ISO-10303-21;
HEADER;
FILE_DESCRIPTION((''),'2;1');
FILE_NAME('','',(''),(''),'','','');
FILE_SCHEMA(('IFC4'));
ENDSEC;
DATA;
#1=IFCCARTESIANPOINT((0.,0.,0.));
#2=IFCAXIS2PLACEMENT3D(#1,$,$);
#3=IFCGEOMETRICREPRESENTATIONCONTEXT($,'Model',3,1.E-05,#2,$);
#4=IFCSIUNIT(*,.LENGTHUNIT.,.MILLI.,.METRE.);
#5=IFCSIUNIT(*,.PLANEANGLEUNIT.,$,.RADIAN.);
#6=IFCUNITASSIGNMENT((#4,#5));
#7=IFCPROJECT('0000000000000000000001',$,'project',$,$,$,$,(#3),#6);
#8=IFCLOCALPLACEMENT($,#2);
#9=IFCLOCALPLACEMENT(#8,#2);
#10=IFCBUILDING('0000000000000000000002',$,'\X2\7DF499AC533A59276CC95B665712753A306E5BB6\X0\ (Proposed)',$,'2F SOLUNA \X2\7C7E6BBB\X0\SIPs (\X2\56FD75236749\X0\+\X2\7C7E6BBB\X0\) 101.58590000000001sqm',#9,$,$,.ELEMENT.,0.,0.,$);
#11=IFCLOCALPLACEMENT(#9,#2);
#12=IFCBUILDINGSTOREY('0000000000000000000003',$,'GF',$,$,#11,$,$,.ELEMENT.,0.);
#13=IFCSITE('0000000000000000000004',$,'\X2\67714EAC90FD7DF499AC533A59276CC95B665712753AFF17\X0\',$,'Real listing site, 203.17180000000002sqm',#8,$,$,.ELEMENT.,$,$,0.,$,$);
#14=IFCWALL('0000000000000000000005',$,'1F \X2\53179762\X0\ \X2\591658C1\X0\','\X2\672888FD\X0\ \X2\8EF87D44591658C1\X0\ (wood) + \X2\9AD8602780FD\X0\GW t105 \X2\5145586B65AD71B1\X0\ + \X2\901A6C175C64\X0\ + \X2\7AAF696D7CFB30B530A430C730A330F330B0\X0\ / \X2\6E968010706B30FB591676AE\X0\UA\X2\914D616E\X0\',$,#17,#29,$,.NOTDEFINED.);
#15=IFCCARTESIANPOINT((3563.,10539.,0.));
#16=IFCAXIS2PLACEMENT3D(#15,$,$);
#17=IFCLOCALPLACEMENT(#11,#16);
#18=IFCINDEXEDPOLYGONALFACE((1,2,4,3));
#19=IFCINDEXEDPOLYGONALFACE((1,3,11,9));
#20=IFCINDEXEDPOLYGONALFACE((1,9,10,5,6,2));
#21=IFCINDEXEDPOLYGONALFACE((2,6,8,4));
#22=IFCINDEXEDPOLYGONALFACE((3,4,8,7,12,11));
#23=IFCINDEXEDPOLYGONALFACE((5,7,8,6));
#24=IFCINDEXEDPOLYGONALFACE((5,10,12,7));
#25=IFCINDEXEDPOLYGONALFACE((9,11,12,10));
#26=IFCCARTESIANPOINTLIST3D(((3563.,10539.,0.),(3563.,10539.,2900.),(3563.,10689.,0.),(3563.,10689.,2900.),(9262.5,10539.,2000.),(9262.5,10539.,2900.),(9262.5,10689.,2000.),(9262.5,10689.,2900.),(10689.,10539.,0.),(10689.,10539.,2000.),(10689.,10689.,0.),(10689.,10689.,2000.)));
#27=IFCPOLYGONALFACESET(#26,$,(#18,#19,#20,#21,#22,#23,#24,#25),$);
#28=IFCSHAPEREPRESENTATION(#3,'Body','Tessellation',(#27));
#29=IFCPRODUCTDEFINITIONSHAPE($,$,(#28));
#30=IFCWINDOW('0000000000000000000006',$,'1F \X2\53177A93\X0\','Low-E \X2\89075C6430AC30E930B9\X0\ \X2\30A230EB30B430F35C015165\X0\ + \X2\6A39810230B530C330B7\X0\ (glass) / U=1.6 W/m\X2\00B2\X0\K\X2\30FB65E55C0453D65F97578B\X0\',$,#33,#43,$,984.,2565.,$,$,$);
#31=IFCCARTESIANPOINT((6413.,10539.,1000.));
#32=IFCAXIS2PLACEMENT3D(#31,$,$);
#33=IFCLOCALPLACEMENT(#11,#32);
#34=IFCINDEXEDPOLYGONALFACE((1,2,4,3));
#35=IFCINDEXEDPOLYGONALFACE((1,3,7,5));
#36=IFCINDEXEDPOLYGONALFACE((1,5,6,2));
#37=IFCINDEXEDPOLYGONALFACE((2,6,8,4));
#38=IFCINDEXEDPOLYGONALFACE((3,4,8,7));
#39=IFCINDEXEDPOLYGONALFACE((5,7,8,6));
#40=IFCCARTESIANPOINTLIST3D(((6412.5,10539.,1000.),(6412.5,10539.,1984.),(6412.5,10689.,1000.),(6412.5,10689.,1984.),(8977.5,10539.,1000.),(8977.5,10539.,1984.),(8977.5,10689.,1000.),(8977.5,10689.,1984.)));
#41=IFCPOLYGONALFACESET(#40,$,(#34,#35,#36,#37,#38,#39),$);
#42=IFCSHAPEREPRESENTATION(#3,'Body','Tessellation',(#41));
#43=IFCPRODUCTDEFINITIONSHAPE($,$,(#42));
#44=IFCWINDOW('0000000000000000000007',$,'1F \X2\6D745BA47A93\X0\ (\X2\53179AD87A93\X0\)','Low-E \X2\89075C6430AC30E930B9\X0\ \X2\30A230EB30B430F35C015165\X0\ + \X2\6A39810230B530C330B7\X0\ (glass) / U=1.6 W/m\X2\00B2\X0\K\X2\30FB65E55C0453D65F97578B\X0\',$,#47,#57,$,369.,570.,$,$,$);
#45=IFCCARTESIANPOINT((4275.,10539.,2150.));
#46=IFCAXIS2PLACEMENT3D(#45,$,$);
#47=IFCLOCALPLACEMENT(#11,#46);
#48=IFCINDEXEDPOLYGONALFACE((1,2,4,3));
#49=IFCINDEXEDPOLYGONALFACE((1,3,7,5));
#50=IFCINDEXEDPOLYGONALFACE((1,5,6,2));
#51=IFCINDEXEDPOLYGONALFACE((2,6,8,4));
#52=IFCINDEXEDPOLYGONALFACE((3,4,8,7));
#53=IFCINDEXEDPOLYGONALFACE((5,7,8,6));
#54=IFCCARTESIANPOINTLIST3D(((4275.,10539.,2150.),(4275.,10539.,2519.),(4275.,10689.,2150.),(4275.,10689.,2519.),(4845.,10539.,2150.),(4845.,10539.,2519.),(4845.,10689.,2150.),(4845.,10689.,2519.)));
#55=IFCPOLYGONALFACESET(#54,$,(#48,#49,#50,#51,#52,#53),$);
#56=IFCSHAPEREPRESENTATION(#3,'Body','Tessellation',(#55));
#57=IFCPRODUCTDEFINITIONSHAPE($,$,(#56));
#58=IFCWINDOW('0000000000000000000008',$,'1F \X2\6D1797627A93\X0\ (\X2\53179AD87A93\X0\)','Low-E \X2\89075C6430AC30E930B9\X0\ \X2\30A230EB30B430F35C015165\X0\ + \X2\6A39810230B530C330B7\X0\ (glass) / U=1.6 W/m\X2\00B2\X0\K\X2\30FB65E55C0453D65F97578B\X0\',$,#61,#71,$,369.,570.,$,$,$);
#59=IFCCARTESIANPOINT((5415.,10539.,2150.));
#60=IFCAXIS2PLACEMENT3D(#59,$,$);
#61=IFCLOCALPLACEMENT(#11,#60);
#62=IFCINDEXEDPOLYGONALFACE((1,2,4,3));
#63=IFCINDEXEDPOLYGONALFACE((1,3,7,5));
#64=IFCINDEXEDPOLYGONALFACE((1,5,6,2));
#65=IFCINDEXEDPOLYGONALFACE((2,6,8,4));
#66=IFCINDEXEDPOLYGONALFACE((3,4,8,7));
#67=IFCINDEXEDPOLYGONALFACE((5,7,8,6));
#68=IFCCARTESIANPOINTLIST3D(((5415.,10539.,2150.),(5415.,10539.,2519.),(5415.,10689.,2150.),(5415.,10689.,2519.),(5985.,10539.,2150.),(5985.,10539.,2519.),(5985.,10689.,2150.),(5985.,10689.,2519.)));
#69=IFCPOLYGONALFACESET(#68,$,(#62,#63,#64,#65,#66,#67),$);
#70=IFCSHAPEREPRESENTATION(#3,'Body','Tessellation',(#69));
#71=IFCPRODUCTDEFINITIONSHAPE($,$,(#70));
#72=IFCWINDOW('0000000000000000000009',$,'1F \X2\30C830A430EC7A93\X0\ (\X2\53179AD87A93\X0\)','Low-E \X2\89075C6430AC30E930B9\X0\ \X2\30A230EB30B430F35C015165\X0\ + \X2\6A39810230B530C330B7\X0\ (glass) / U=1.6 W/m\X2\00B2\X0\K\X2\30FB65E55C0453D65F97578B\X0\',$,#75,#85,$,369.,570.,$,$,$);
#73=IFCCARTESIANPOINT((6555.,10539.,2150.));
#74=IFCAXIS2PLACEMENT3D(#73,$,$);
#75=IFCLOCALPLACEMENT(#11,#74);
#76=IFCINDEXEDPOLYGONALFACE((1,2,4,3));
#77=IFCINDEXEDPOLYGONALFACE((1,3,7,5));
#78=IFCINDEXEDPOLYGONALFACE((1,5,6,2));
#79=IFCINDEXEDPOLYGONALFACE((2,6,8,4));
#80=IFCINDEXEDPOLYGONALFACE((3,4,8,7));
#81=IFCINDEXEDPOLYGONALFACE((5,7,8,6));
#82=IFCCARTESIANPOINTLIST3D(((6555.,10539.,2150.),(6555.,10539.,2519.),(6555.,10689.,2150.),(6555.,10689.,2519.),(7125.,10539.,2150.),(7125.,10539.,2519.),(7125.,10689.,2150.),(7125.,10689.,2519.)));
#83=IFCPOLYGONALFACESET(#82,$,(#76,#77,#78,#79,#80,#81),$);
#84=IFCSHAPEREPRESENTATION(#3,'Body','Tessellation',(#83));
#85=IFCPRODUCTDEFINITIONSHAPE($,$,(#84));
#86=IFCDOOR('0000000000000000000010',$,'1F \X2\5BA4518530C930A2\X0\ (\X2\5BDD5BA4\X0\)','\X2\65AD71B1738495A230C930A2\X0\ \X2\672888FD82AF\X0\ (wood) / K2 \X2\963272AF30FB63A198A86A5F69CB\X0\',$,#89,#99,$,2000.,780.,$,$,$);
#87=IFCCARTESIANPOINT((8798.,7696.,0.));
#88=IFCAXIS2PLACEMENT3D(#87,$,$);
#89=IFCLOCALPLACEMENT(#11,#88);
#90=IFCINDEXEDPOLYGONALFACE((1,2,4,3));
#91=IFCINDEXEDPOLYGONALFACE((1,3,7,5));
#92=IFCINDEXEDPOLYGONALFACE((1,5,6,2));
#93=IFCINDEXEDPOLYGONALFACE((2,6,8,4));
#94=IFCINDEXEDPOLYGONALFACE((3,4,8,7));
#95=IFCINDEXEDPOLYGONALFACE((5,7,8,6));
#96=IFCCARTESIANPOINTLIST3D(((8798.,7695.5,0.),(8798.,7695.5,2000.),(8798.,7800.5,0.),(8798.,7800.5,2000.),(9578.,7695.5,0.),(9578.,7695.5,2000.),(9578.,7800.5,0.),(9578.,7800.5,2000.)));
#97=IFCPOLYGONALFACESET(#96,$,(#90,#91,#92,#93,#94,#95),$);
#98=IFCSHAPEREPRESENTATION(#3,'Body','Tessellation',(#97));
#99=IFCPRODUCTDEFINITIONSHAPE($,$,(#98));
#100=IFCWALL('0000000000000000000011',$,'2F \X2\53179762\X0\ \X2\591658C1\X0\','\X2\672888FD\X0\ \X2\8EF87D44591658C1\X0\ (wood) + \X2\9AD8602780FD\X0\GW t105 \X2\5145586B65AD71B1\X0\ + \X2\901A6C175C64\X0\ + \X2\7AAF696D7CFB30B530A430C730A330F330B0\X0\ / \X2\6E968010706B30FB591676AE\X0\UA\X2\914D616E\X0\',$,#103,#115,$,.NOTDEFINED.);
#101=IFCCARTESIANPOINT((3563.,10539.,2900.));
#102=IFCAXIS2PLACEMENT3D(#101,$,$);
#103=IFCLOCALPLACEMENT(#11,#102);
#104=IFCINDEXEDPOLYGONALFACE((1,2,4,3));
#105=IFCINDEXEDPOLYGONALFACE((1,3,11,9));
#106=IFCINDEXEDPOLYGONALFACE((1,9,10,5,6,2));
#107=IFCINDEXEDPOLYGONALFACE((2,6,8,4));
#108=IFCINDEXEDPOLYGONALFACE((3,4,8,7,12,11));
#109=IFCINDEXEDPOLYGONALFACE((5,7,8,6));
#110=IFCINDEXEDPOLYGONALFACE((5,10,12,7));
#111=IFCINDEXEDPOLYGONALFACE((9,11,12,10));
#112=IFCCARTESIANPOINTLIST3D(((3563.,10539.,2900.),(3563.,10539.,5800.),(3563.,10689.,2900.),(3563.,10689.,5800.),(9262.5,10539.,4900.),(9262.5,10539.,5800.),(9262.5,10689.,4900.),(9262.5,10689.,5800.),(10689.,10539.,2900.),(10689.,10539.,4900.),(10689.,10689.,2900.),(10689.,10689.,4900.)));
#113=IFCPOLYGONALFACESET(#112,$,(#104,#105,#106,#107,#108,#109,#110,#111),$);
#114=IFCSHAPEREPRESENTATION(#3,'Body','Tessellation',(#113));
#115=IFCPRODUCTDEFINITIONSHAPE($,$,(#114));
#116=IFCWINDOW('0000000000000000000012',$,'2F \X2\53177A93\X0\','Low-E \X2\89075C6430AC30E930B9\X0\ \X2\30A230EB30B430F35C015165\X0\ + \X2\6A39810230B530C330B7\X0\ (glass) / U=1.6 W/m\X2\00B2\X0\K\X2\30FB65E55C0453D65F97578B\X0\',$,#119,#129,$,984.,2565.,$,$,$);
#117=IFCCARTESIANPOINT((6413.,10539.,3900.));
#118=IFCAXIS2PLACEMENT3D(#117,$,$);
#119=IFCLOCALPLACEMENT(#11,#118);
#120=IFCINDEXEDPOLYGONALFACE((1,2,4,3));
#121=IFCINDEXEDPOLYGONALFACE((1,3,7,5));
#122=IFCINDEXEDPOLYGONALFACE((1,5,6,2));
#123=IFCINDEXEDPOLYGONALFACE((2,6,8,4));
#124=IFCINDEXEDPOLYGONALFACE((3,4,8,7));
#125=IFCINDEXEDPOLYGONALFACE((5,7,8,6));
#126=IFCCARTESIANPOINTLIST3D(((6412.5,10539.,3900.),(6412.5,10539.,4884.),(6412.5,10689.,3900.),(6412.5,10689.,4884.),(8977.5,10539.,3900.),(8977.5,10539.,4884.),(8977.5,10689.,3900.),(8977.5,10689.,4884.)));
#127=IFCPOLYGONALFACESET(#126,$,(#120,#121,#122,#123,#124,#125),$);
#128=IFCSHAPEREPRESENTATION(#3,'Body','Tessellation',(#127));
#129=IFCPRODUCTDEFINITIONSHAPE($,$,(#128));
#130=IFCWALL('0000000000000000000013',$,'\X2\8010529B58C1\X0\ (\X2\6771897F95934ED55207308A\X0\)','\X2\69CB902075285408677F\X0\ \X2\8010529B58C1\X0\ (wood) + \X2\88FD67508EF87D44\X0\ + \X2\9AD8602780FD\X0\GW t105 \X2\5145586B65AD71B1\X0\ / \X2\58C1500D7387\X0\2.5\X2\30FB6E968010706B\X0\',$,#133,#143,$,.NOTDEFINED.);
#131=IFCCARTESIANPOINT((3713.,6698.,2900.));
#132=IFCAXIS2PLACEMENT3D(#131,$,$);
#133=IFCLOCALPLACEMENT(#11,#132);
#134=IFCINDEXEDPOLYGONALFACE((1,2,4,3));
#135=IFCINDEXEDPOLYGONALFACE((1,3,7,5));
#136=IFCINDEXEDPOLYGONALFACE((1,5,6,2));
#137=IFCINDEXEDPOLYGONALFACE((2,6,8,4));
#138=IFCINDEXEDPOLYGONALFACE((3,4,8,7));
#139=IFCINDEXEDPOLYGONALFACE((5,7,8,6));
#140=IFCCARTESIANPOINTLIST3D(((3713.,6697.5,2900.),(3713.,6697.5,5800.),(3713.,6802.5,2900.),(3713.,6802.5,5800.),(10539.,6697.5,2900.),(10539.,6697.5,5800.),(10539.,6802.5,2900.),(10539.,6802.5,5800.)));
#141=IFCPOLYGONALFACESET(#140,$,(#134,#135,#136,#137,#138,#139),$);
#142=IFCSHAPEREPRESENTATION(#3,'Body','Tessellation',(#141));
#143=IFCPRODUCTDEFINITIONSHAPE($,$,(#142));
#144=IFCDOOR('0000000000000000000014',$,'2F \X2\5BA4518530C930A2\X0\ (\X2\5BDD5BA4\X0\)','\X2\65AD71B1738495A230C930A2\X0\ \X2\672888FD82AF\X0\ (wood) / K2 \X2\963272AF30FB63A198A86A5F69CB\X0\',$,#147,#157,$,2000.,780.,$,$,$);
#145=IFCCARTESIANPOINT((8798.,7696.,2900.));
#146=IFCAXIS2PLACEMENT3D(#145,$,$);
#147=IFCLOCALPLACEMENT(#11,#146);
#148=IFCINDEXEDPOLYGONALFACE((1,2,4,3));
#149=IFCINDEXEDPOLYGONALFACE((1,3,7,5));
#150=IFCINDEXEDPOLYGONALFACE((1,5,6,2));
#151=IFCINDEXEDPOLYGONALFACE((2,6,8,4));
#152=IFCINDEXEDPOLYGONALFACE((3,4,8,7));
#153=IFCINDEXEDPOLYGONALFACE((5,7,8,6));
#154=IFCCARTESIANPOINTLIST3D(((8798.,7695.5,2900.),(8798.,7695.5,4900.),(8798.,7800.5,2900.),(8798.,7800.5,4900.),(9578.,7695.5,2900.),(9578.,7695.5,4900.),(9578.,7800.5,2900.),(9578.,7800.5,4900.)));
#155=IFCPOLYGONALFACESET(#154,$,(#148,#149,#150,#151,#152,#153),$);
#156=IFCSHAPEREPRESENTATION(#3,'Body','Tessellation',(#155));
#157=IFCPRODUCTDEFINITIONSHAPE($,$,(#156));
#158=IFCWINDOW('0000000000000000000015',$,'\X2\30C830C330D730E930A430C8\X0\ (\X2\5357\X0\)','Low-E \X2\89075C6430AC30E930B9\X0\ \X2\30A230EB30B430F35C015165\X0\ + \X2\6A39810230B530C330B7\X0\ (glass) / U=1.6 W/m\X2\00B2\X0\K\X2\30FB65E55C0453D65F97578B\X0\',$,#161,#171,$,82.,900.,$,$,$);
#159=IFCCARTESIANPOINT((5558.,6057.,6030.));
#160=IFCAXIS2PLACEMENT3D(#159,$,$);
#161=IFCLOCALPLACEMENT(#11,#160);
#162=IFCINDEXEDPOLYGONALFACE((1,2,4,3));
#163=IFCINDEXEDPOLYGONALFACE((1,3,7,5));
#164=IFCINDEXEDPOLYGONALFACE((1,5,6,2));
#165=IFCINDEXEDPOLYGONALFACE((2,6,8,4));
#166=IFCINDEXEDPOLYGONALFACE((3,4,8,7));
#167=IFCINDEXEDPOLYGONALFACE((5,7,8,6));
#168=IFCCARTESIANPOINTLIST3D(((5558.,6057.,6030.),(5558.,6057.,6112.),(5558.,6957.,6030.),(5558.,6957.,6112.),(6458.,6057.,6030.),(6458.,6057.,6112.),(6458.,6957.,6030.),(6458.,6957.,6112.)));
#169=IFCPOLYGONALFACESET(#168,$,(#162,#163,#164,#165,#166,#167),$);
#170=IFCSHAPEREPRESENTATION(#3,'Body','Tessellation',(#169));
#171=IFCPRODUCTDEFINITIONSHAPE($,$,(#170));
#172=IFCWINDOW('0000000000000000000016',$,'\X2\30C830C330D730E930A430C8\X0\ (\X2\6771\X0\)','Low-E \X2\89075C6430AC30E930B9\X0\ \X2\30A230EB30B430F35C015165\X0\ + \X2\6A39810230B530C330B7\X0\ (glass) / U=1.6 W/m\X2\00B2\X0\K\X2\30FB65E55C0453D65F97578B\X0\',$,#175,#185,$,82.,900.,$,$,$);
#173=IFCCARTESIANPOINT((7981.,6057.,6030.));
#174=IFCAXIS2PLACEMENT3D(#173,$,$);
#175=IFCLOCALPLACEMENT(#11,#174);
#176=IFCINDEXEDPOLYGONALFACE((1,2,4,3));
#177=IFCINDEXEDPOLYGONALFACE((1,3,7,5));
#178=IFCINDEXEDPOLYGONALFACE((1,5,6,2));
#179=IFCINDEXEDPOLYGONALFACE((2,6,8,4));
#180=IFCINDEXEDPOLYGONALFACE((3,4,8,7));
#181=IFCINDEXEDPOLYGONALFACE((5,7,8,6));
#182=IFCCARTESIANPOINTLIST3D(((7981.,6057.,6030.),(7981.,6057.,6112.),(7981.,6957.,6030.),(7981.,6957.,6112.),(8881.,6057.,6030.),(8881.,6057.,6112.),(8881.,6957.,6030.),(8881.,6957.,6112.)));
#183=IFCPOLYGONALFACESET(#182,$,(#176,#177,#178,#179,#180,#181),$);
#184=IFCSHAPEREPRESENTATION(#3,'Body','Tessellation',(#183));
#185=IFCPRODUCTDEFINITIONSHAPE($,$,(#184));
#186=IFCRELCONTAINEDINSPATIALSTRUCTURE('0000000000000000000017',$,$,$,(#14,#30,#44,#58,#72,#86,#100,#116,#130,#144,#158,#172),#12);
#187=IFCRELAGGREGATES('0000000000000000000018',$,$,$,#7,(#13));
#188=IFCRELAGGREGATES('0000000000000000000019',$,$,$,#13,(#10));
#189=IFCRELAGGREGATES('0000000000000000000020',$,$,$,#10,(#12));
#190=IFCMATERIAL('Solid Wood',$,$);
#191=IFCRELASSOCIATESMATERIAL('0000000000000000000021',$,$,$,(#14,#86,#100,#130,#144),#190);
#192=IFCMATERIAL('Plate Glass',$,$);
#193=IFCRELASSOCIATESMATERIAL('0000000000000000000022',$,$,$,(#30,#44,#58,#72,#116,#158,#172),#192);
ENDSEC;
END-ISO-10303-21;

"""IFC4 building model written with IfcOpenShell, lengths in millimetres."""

from ifc_helpers import new_model, si_unit, frame, frame_2d, origin, place, context, project, spatial, rectangle, extrude, material, element, fill, save


model = new_model("IFC4")

# Units and contexts
model_context = context("Model", 3, precision=1e-05, world=origin())
ifc_project = project(units=[si_unit("LENGTHUNIT", "METRE", prefix="MILLI"), si_unit("PLANEANGLEUNIT", "RADIAN")], contexts=[model_context])

# Site, building, storey
site_placement = place(None, origin())
site = spatial("IfcSite", under=ifc_project, at=site_placement, Name="東京都練馬区大泉学園町７", ObjectType="Real listing site, 203.17180000000002sqm", CompositionType="ELEMENT", RefElevation=0.0)
building_placement = place(site_placement, origin())
building = spatial("IfcBuilding", under=site, at=building_placement, Name="練馬区大泉学園町の家 (Proposed)", ObjectType="2F SOLUNA 籾殻SIPs (国産杉+籾殻) 101.58590000000001sqm", CompositionType="ELEMENT", ElevationOfRefHeight=0.0, ElevationOfTerrain=0.0)
storey_placement = place(building_placement, origin())
storey = spatial("IfcBuildingStorey", under=building, at=storey_placement, Name="GF", CompositionType="ELEMENT", Elevation=0.0)

# Wall, openings, windows
ifc_material_1 = material(Name="Solid Wood")
wall_1_placement = place(storey_placement, frame((3563.0, 10539.0, 0.0)))
wall_1 = element("IfcWall", 1, at=wall_1_placement, inside=storey, material=ifc_material_1, Name="1F 北面 外壁", Description="木製 軸組外壁 (wood) + 高性能GW t105 充填断熱 + 通気層 + 窯業系サイディング / 準耐火・外皮UA配慮", PredefinedType="NOTDEFINED", context=model_context, shape_type="SweptSolid", body=[
    extrude(rectangle(XDim=7126.0, YDim=150.0, at=frame_2d((3563.0, 75.0))), frame((3563.0, 10539.0, 0.0)), (0.0, 0.0, 1.0), 2900.0),
])
opening_1_placement = place(storey_placement, frame((6413.0, 10539.0, 1000.0)))
opening_1 = element("IfcOpeningElement", 2, at=opening_1_placement, cuts=wall_1, PredefinedType="NOTDEFINED", context=model_context, shape_type="SweptSolid", body=[
    extrude(rectangle(XDim=2565.0, YDim=150.0, at=frame_2d((1282.0, 75.0))), frame((6413.0, 10539.0, 1000.0)), (0.0, 0.0, 1.0), 984.0),
])
opening_2_placement = place(storey_placement, frame((4275.0, 10539.0, 2150.0)))
opening_2 = element("IfcOpeningElement", 3, at=opening_2_placement, cuts=wall_1, PredefinedType="NOTDEFINED", context=model_context, shape_type="SweptSolid", body=[
    extrude(rectangle(XDim=570.0, YDim=150.0, at=frame_2d((285.0, 75.0))), frame((4275.0, 10539.0, 2150.0)), (0.0, 0.0, 1.0), 369.0),
])
opening_3_placement = place(storey_placement, frame((5415.0, 10539.0, 2150.0)))
opening_3 = element("IfcOpeningElement", 4, at=opening_3_placement, cuts=wall_1, PredefinedType="NOTDEFINED", context=model_context, shape_type="SweptSolid", body=[
    extrude(rectangle(XDim=570.0, YDim=150.0, at=frame_2d((285.0, 75.0))), frame((5415.0, 10539.0, 2150.0)), (0.0, 0.0, 1.0), 369.0),
])
opening_4_placement = place(storey_placement, frame((6555.0, 10539.0, 2150.0)))
opening_4 = element("IfcOpeningElement", 5, at=opening_4_placement, cuts=wall_1, PredefinedType="NOTDEFINED", context=model_context, shape_type="SweptSolid", body=[
    extrude(rectangle(XDim=570.0, YDim=150.0, at=frame_2d((285.0, 75.0))), frame((6555.0, 10539.0, 2150.0)), (0.0, 0.0, 1.0), 369.0),
])
ifc_material_2 = material(Name="Plate Glass")
window_1_placement = place(storey_placement, frame((6413.0, 10539.0, 1000.0)))
window_1 = element("IfcWindow", 6, at=window_1_placement, inside=storey, material=ifc_material_2, Name="1F 北窓", Description="Low-E 複層ガラス アルゴン封入 + 樹脂サッシ (glass) / U=1.6 W/m²K・日射取得型", OverallHeight=984.0, OverallWidth=2565.0, context=model_context, shape_type="SweptSolid", body=[
    extrude(rectangle(XDim=2565.0, YDim=150.0, at=frame_2d((1282.0, 75.0))), frame((6413.0, 10539.0, 1000.0)), (0.0, 0.0, 1.0), 984.0),
])
fill(opening_1, window_1)
window_2_placement = place(storey_placement, frame((4275.0, 10539.0, 2150.0)))
window_2 = element("IfcWindow", 7, at=window_2_placement, inside=storey, material=ifc_material_2, Name="1F 浴室窓 (北高窓)", Description="Low-E 複層ガラス アルゴン封入 + 樹脂サッシ (glass) / U=1.6 W/m²K・日射取得型", OverallHeight=369.0, OverallWidth=570.0, context=model_context, shape_type="SweptSolid", body=[
    extrude(rectangle(XDim=570.0, YDim=150.0, at=frame_2d((285.0, 75.0))), frame((4275.0, 10539.0, 2150.0)), (0.0, 0.0, 1.0), 369.0),
])
fill(opening_2, window_2)
window_3_placement = place(storey_placement, frame((5415.0, 10539.0, 2150.0)))
window_3 = element("IfcWindow", 8, at=window_3_placement, inside=storey, material=ifc_material_2, Name="1F 洗面窓 (北高窓)", Description="Low-E 複層ガラス アルゴン封入 + 樹脂サッシ (glass) / U=1.6 W/m²K・日射取得型", OverallHeight=369.0, OverallWidth=570.0, context=model_context, shape_type="SweptSolid", body=[
    extrude(rectangle(XDim=570.0, YDim=150.0, at=frame_2d((285.0, 75.0))), frame((5415.0, 10539.0, 2150.0)), (0.0, 0.0, 1.0), 369.0),
])
fill(opening_3, window_3)
window_4_placement = place(storey_placement, frame((6555.0, 10539.0, 2150.0)))
window_4 = element("IfcWindow", 9, at=window_4_placement, inside=storey, material=ifc_material_2, Name="1F トイレ窓 (北高窓)", Description="Low-E 複層ガラス アルゴン封入 + 樹脂サッシ (glass) / U=1.6 W/m²K・日射取得型", OverallHeight=369.0, OverallWidth=570.0, context=model_context, shape_type="SweptSolid", body=[
    extrude(rectangle(XDim=570.0, YDim=150.0, at=frame_2d((285.0, 75.0))), frame((6555.0, 10539.0, 2150.0)), (0.0, 0.0, 1.0), 369.0),
])
fill(opening_4, window_4)

# Door
door_1_placement = place(storey_placement, frame((8798.0, 7696.0, 0.0)))
element("IfcDoor", 10, at=door_1_placement, inside=storey, material=ifc_material_1, Name="1F 室内ドア (寝室)", Description="断熱玄関ドア 木製芯 (wood) / K2 防犯・採風機構", OverallHeight=2000.0, OverallWidth=780.0, context=model_context, shape_type="SweptSolid", body=[
    extrude(rectangle(XDim=780.0, YDim=105.0, at=frame_2d((390.0, 52.0))), frame((8798.0, 7696.0, 0.0)), (0.0, 0.0, 1.0), 2000.0),
])

# Wall, opening, window
wall_2_placement = place(storey_placement, frame((3563.0, 10539.0, 2900.0)))
wall_2 = element("IfcWall", 11, at=wall_2_placement, inside=storey, material=ifc_material_1, Name="2F 北面 外壁", Description="木製 軸組外壁 (wood) + 高性能GW t105 充填断熱 + 通気層 + 窯業系サイディング / 準耐火・外皮UA配慮", PredefinedType="NOTDEFINED", context=model_context, shape_type="SweptSolid", body=[
    extrude(rectangle(XDim=7126.0, YDim=150.0, at=frame_2d((3563.0, 75.0))), frame((3563.0, 10539.0, 2900.0)), (0.0, 0.0, 1.0), 2900.0),
])
opening_5_placement = place(storey_placement, frame((6413.0, 10539.0, 3900.0)))
opening_5 = element("IfcOpeningElement", 12, at=opening_5_placement, cuts=wall_2, PredefinedType="NOTDEFINED", context=model_context, shape_type="SweptSolid", body=[
    extrude(rectangle(XDim=2565.0, YDim=150.0, at=frame_2d((1282.0, 75.0))), frame((6413.0, 10539.0, 3900.0)), (0.0, 0.0, 1.0), 984.0),
])
window_5_placement = place(storey_placement, frame((6413.0, 10539.0, 3900.0)))
window_5 = element("IfcWindow", 13, at=window_5_placement, inside=storey, material=ifc_material_2, Name="2F 北窓", Description="Low-E 複層ガラス アルゴン封入 + 樹脂サッシ (glass) / U=1.6 W/m²K・日射取得型", OverallHeight=984.0, OverallWidth=2565.0, context=model_context, shape_type="SweptSolid", body=[
    extrude(rectangle(XDim=2565.0, YDim=150.0, at=frame_2d((1282.0, 75.0))), frame((6413.0, 10539.0, 3900.0)), (0.0, 0.0, 1.0), 984.0),
])
fill(opening_5, window_5)

# Wall
wall_3_placement = place(storey_placement, frame((3713.0, 6698.0, 2900.0)))
element("IfcWall", 14, at=wall_3_placement, inside=storey, material=ifc_material_1, Name="耐力壁 (東西間仕切り)", Description="構造用合板 耐力壁 (wood) + 製材軸組 + 高性能GW t105 充填断熱 / 壁倍率2.5・準耐火", PredefinedType="NOTDEFINED", context=model_context, shape_type="SweptSolid", body=[
    extrude(rectangle(XDim=6826.0, YDim=105.0, at=frame_2d((3413.0, 52.0))), frame((3713.0, 6698.0, 2900.0)), (0.0, 0.0, 1.0), 2900.0),
])

# Door
door_2_placement = place(storey_placement, frame((8798.0, 7696.0, 2900.0)))
element("IfcDoor", 15, at=door_2_placement, inside=storey, material=ifc_material_1, Name="2F 室内ドア (寝室)", Description="断熱玄関ドア 木製芯 (wood) / K2 防犯・採風機構", OverallHeight=2000.0, OverallWidth=780.0, context=model_context, shape_type="SweptSolid", body=[
    extrude(rectangle(XDim=780.0, YDim=105.0, at=frame_2d((390.0, 52.0))), frame((8798.0, 7696.0, 2900.0)), (0.0, 0.0, 1.0), 2000.0),
])

# Windows
window_6_placement = place(storey_placement, frame((5558.0, 6057.0, 6030.0)))
element("IfcWindow", 16, at=window_6_placement, inside=storey, material=ifc_material_2, Name="トップライト (南)", Description="Low-E 複層ガラス アルゴン封入 + 樹脂サッシ (glass) / U=1.6 W/m²K・日射取得型", OverallHeight=82.0, OverallWidth=900.0, context=model_context, shape_type="SweptSolid", body=[
    extrude(rectangle(XDim=900.0, YDim=900.0, at=frame_2d((450.0, 450.0))), frame((5558.0, 6057.0, 6030.0)), (0.0, 0.0, 1.0), 82.0),
])
window_7_placement = place(storey_placement, frame((7981.0, 6057.0, 6030.0)))
element("IfcWindow", 17, at=window_7_placement, inside=storey, material=ifc_material_2, Name="トップライト (東)", Description="Low-E 複層ガラス アルゴン封入 + 樹脂サッシ (glass) / U=1.6 W/m²K・日射取得型", OverallHeight=82.0, OverallWidth=900.0, context=model_context, shape_type="SweptSolid", body=[
    extrude(rectangle(XDim=900.0, YDim=900.0, at=frame_2d((450.0, 450.0))), frame((7981.0, 6057.0, 6030.0)), (0.0, 0.0, 1.0), 82.0),
])

save(model, "model.ifc")
